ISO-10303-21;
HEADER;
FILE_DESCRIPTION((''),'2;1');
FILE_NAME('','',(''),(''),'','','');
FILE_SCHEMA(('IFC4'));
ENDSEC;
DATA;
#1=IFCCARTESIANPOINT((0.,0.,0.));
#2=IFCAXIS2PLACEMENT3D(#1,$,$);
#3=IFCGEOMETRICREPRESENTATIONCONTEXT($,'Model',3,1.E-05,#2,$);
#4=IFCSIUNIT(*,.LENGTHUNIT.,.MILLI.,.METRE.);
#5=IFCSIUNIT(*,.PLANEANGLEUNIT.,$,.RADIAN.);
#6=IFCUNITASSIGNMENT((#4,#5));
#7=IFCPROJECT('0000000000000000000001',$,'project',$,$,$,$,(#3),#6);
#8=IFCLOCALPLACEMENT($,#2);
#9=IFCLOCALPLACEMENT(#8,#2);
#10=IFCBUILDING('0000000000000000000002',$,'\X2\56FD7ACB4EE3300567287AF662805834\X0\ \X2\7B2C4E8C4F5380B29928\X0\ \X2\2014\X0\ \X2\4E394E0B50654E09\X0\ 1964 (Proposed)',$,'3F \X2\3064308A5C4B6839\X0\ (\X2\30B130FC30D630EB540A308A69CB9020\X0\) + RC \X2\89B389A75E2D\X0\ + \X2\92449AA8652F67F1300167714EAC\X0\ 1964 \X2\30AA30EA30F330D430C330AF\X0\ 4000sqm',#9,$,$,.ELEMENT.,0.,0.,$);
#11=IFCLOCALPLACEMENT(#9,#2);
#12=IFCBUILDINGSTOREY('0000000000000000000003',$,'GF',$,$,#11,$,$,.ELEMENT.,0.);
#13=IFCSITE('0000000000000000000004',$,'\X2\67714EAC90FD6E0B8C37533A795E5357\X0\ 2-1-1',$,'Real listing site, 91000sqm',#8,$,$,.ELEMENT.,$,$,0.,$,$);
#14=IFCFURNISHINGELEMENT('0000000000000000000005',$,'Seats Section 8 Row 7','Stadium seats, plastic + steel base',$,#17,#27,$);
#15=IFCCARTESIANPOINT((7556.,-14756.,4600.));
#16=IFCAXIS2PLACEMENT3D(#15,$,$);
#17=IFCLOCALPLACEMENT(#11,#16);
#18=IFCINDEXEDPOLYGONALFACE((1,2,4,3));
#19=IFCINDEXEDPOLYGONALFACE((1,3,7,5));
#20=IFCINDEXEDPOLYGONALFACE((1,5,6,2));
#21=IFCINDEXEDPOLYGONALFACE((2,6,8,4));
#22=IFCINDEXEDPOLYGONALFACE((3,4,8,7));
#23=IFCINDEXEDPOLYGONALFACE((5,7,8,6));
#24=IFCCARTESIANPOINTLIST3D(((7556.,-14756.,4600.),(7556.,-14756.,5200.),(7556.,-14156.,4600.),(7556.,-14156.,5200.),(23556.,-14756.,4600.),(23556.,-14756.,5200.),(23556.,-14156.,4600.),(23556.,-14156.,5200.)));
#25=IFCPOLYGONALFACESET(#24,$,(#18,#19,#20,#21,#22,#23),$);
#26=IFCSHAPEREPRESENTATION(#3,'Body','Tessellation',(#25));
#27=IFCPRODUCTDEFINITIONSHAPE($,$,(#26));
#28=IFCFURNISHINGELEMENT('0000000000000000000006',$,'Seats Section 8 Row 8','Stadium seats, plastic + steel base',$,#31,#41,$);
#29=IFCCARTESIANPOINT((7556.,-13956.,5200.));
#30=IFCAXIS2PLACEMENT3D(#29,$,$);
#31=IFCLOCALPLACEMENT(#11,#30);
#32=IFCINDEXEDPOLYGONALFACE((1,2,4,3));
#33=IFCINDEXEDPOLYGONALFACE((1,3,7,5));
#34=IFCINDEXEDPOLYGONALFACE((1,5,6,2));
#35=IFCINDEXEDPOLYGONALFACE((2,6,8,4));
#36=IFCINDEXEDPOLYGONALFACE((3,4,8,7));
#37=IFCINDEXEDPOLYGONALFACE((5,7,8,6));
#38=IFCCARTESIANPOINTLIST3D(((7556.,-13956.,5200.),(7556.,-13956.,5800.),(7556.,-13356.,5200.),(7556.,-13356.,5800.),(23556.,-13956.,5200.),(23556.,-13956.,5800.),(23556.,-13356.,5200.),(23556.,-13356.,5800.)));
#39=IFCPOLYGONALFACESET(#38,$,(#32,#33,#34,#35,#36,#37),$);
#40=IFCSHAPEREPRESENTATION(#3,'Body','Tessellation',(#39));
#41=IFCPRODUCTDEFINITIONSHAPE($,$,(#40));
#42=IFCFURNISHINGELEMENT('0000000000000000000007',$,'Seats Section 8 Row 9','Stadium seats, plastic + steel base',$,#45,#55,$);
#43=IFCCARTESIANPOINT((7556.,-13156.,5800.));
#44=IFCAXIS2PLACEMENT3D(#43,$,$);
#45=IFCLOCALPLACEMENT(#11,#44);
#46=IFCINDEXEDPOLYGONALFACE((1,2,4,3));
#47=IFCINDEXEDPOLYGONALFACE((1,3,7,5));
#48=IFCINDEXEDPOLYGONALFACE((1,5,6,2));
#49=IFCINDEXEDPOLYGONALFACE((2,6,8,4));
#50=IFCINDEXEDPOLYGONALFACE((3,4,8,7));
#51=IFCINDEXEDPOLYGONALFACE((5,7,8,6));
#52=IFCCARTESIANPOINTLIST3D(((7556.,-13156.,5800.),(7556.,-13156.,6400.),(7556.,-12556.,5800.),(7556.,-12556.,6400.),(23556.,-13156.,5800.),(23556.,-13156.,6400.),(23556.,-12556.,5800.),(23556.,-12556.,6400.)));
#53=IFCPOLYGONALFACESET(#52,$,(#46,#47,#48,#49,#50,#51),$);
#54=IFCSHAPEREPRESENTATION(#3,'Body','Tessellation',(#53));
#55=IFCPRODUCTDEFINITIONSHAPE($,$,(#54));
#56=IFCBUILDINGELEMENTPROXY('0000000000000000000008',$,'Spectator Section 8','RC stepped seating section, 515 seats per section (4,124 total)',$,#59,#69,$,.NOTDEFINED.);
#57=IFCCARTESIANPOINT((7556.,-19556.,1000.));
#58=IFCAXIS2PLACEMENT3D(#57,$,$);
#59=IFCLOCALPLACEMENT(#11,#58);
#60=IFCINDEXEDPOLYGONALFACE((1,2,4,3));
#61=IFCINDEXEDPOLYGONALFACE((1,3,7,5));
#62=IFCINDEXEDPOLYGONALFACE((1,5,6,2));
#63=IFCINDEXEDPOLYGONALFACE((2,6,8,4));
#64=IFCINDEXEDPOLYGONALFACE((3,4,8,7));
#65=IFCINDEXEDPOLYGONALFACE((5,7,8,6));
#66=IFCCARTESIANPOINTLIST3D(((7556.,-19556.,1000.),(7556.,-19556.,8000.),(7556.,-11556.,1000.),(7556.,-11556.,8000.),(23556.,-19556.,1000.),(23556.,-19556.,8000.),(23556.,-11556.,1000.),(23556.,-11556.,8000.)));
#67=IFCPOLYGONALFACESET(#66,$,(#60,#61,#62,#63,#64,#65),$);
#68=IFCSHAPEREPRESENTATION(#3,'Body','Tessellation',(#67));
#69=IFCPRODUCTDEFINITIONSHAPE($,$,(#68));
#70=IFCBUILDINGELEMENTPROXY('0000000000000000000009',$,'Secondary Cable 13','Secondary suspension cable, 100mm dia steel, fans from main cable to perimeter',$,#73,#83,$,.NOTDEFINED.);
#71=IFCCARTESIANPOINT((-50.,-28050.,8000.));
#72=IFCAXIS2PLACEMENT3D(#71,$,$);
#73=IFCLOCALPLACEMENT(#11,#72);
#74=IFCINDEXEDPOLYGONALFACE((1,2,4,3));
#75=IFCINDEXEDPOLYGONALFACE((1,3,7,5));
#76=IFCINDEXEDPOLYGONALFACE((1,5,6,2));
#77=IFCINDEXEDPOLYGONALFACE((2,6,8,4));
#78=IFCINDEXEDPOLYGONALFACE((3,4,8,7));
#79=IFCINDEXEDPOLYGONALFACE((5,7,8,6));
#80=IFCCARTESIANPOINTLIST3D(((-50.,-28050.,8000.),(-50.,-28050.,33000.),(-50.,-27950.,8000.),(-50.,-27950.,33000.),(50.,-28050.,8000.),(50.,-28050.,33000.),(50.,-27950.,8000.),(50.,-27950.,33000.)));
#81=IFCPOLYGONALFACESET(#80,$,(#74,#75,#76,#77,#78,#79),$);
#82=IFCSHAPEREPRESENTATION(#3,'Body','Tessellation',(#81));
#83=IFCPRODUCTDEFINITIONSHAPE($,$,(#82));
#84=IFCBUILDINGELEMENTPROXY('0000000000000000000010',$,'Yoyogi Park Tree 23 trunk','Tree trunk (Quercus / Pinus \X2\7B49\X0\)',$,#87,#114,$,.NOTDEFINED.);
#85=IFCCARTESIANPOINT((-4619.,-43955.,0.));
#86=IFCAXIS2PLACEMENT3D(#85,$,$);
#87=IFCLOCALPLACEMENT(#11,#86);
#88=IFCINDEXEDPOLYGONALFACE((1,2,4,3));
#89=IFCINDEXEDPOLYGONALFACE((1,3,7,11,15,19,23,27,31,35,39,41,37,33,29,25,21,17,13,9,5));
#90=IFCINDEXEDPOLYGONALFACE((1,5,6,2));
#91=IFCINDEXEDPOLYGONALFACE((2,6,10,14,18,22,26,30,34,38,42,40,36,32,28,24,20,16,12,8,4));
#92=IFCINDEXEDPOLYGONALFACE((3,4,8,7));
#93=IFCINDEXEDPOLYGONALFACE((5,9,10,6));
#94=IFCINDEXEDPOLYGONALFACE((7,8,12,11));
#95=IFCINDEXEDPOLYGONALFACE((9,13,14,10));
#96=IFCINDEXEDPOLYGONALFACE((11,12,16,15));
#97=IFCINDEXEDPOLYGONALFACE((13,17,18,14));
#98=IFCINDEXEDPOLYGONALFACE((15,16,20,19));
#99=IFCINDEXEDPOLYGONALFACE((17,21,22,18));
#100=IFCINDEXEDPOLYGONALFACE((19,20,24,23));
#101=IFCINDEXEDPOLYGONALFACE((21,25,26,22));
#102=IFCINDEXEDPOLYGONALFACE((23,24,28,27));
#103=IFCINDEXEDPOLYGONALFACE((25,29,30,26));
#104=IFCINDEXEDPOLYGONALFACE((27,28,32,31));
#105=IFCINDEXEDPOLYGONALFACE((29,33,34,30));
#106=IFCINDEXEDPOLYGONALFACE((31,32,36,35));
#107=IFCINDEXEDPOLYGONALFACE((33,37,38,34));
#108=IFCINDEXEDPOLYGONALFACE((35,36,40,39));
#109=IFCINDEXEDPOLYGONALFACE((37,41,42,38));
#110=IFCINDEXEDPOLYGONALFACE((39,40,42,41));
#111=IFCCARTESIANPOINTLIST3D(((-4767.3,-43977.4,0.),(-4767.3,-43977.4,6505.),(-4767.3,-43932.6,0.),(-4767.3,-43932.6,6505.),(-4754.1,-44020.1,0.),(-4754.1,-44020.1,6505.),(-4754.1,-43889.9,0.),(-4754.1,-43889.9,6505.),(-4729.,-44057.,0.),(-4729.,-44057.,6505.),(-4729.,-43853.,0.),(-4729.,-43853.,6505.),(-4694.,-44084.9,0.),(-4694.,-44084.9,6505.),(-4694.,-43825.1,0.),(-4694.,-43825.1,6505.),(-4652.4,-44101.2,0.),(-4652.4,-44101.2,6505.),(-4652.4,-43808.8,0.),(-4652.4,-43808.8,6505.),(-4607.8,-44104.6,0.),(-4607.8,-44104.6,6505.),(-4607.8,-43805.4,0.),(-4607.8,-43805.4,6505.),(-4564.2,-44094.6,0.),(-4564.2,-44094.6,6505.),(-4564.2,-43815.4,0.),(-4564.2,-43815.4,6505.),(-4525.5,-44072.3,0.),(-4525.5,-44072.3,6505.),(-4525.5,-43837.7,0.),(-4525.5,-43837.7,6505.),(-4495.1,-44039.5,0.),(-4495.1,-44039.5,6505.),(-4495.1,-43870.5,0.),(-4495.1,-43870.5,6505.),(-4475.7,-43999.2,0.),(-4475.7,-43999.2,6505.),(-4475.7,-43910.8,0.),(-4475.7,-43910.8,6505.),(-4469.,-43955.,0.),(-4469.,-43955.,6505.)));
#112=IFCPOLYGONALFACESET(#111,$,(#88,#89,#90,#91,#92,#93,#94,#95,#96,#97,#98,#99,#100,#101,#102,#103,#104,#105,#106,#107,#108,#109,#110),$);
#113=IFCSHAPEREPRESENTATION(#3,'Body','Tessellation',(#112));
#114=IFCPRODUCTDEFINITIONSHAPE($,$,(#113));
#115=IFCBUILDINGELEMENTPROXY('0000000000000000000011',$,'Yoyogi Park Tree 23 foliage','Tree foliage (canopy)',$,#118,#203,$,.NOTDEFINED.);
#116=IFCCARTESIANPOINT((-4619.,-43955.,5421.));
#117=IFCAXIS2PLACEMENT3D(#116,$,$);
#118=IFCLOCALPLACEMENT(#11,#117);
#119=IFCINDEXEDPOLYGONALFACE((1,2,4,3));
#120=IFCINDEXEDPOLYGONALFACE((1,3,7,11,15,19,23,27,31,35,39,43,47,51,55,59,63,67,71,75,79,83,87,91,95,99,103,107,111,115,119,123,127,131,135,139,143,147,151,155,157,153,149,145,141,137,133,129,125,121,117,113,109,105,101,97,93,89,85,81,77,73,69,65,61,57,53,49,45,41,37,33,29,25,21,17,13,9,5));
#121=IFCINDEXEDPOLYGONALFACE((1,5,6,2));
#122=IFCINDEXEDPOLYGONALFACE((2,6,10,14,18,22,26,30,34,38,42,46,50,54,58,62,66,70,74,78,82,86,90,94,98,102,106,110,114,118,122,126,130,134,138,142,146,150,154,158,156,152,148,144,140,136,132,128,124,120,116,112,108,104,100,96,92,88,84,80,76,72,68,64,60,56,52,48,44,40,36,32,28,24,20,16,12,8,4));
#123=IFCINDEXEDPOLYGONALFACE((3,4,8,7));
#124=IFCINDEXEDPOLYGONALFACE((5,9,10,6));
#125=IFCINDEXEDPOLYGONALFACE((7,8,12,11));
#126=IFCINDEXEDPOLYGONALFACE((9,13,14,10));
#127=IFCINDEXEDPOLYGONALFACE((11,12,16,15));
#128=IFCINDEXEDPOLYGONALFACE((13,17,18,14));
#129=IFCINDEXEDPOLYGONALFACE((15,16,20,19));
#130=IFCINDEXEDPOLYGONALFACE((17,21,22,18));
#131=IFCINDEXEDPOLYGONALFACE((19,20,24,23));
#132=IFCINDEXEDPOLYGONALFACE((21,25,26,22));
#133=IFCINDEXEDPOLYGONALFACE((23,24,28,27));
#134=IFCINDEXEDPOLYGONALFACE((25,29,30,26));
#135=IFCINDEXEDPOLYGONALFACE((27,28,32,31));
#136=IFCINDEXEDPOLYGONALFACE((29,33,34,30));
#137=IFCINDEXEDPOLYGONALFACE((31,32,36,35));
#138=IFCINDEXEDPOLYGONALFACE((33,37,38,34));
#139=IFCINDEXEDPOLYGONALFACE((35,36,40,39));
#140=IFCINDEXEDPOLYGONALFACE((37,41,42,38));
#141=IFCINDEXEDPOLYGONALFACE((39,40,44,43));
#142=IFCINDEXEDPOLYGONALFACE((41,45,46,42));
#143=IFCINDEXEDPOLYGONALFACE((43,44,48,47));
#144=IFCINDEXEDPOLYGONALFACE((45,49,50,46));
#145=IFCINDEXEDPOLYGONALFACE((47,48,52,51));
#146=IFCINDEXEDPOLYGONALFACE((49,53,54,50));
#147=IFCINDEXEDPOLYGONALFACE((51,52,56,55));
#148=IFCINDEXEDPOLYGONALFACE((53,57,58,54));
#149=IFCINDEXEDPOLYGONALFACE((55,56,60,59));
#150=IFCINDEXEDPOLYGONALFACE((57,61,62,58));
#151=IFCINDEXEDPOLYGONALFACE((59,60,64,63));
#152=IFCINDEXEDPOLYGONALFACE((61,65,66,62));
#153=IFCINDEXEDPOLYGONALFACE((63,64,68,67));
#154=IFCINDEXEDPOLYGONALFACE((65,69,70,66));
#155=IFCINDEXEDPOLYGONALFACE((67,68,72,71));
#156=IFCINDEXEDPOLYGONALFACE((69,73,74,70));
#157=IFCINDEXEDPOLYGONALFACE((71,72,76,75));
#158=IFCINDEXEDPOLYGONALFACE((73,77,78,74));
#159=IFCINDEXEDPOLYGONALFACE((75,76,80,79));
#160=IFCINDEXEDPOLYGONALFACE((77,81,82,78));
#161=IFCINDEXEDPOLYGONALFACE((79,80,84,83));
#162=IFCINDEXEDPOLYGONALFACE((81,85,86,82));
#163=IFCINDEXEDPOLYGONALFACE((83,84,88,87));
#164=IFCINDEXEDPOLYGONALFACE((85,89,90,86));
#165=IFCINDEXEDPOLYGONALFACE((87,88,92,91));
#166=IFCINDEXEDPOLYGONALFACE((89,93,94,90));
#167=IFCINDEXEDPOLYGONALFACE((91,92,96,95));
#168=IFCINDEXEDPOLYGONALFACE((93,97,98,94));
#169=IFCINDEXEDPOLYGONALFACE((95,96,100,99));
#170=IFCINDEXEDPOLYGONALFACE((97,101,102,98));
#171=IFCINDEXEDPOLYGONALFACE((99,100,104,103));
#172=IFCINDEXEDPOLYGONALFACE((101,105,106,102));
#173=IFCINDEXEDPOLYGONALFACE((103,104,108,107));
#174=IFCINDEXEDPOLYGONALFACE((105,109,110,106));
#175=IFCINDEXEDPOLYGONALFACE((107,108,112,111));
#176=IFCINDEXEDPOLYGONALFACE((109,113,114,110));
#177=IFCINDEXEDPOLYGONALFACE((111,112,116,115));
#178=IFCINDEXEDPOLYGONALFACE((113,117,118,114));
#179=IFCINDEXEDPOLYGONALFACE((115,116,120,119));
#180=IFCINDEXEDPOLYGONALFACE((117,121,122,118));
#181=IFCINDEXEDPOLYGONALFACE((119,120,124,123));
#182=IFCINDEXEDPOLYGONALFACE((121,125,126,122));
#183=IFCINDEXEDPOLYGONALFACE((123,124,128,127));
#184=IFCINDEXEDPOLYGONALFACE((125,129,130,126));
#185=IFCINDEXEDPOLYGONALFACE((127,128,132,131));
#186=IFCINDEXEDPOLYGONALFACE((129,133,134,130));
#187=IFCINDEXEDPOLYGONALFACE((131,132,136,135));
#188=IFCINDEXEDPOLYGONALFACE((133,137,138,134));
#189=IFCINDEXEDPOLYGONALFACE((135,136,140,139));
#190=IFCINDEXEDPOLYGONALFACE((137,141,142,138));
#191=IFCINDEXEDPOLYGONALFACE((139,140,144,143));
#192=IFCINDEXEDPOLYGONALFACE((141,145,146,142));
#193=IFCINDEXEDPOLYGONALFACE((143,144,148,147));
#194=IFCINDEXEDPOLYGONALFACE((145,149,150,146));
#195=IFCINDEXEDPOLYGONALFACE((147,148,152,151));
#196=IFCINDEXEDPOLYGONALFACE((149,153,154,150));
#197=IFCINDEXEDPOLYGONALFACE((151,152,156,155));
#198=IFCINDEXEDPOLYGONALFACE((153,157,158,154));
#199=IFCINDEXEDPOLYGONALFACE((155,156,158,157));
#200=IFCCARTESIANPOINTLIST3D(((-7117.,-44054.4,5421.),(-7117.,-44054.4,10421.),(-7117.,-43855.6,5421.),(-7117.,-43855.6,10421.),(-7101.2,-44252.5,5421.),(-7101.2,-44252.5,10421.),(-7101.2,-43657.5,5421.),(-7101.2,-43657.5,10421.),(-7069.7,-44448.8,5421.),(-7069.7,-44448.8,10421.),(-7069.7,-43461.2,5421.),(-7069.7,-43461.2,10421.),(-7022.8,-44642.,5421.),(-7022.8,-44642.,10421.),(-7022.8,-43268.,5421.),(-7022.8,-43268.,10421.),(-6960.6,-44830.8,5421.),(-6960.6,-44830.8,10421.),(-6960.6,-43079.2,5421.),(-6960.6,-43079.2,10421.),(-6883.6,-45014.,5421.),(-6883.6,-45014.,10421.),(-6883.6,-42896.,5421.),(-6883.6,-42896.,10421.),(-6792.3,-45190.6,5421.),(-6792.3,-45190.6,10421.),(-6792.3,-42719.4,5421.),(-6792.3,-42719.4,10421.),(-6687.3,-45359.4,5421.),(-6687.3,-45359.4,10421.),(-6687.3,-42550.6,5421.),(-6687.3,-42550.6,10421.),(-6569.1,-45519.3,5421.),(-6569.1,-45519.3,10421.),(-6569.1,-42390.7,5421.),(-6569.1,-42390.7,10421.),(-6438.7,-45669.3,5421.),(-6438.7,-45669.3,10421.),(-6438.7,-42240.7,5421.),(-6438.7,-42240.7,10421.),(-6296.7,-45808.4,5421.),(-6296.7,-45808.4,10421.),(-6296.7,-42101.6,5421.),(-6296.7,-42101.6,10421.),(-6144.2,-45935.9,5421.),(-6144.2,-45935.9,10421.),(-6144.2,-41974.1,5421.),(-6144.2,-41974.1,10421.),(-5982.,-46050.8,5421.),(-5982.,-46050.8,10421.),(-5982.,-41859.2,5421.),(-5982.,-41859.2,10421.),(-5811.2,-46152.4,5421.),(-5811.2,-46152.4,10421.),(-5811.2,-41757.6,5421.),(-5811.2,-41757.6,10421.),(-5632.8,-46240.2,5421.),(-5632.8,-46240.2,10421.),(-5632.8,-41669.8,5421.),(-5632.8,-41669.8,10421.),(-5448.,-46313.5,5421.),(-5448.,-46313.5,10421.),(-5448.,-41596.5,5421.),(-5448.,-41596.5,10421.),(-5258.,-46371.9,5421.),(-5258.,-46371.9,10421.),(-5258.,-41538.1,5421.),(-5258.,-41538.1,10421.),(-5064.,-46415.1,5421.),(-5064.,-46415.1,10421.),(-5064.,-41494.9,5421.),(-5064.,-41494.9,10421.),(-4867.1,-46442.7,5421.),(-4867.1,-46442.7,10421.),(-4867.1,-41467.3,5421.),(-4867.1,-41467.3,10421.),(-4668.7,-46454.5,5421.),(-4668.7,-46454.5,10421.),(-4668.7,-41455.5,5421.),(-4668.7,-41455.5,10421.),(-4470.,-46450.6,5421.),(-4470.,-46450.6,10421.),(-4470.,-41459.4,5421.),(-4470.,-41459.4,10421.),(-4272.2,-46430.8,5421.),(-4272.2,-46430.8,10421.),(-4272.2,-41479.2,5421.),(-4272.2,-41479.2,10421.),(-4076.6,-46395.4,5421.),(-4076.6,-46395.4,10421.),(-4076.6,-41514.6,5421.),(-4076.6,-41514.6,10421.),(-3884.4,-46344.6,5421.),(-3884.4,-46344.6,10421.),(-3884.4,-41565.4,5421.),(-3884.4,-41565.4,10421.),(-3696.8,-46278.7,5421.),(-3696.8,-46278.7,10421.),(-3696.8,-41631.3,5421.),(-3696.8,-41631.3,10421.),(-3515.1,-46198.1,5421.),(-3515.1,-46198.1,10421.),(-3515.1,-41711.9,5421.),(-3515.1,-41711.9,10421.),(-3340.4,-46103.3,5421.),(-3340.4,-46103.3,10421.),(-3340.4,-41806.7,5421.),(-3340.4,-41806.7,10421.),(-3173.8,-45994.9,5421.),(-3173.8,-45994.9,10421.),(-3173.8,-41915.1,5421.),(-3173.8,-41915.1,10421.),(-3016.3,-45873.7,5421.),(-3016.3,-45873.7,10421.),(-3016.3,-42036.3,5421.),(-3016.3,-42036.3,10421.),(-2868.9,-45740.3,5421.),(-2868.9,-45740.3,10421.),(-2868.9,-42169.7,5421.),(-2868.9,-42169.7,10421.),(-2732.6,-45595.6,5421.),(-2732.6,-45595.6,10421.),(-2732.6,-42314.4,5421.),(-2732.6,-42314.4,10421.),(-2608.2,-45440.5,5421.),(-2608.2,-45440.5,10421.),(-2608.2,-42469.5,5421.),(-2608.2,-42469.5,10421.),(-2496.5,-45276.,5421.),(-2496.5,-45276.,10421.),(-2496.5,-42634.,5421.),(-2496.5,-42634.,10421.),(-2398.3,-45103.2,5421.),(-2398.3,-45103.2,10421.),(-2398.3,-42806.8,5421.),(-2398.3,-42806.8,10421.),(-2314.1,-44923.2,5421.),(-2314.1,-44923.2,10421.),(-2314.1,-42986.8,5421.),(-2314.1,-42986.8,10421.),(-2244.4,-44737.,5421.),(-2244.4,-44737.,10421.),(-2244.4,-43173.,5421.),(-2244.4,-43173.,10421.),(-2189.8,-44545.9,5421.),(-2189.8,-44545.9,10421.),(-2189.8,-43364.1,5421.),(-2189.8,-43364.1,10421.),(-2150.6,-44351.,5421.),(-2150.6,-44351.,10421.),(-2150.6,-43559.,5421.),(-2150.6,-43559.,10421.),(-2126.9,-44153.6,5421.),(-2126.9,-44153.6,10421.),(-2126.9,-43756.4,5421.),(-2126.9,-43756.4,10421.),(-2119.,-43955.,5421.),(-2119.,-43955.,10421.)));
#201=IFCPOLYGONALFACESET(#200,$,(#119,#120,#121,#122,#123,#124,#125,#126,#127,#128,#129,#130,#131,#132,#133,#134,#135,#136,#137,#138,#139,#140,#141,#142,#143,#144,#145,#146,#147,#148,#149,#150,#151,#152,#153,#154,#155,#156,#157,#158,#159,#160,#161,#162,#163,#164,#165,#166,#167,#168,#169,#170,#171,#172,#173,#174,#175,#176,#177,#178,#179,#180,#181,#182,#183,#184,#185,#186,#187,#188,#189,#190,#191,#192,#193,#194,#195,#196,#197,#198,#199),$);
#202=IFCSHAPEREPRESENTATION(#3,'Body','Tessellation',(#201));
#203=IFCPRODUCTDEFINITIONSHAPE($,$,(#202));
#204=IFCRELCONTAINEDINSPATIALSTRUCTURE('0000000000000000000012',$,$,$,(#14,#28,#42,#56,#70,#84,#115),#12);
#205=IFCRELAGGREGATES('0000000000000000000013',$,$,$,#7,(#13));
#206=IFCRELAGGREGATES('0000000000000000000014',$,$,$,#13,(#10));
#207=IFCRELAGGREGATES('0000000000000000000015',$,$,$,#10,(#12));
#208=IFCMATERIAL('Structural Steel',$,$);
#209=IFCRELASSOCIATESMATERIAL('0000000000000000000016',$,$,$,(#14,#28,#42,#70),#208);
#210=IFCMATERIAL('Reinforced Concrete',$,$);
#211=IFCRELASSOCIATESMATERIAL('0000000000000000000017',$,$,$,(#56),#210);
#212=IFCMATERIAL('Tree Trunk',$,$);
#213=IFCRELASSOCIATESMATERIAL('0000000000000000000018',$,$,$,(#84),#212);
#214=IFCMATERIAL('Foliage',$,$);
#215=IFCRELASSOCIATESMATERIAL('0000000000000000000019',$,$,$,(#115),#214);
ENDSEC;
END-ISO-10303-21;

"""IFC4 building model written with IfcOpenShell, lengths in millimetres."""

from ifc_helpers import new_model, si_unit, frame, frame_2d, origin, origin_2d, place, context, project, spatial, rectangle, circle, extrude, material, element, save


model = new_model("IFC4")

# Units and contexts
model_context = context("Model", 3, precision=1e-05, world=origin())
ifc_project = project(units=[si_unit("LENGTHUNIT", "METRE", prefix="MILLI"), si_unit("PLANEANGLEUNIT", "RADIAN")], contexts=[model_context])

# Site, building, storey
site_placement = place(None, origin())
site = spatial("IfcSite", under=ifc_project, at=site_placement, Name="東京都渋谷区神南 2-1-1", ObjectType="Real listing site, 91000sqm", CompositionType="ELEMENT", RefElevation=0.0)
building_placement = place(site_placement, origin())
building = spatial("IfcBuilding", under=site, at=building_placement, Name="国立代々木競技場 第二体育館 — 丹下健三 1964 (Proposed)", ObjectType="3F つり屋根 (ケーブル吊り構造) + RC 観覧席 + 鉄骨支柱、東京 1964 オリンピック 4000sqm", CompositionType="ELEMENT", ElevationOfRefHeight=0.0, ElevationOfTerrain=0.0)
storey_placement = place(building_placement, origin())
storey = spatial("IfcBuildingStorey", under=building, at=storey_placement, Name="GF", CompositionType="ELEMENT", Elevation=0.0)

# Shared definitions
ifc_material_1 = material(Name="Structural Steel")

# Furnishing elements
furnishing_1_placement = place(storey_placement, frame((7556.0, -14756.0, 4600.0)))
element("IfcFurnishingElement", 1, at=furnishing_1_placement, inside=storey, material=ifc_material_1, Name="Seats Section 8 Row 7", Description="Stadium seats, plastic + steel base", context=model_context, shape_type="SweptSolid", body=[
    extrude(rectangle(XDim=16000.0, YDim=600.0, at=frame_2d((8000.0, 300.0))), frame((7556.0, -14756.0, 4600.0)), (0.0, 0.0, 1.0), 600.0),
])
furnishing_2_placement = place(storey_placement, frame((7556.0, -13956.0, 5200.0)))
element("IfcFurnishingElement", 2, at=furnishing_2_placement, inside=storey, material=ifc_material_1, Name="Seats Section 8 Row 8", Description="Stadium seats, plastic + steel base", context=model_context, shape_type="SweptSolid", body=[
    extrude(rectangle(XDim=16000.0, YDim=600.0, at=frame_2d((8000.0, 300.0))), frame((7556.0, -13956.0, 5200.0)), (0.0, 0.0, 1.0), 600.0),
])
furnishing_3_placement = place(storey_placement, frame((7556.0, -13156.0, 5800.0)))
element("IfcFurnishingElement", 3, at=furnishing_3_placement, inside=storey, material=ifc_material_1, Name="Seats Section 8 Row 9", Description="Stadium seats, plastic + steel base", context=model_context, shape_type="SweptSolid", body=[
    extrude(rectangle(XDim=16000.0, YDim=600.0, at=frame_2d((8000.0, 300.0))), frame((7556.0, -13156.0, 5800.0)), (0.0, 0.0, 1.0), 600.0),
])

# Building element proxies
ifc_material_2 = material(Name="Reinforced Concrete")
proxy_1_placement = place(storey_placement, frame((7556.0, -19556.0, 1000.0)))
element("IfcBuildingElementProxy", 4, at=proxy_1_placement, inside=storey, material=ifc_material_2, Name="Spectator Section 8", Description="RC stepped seating section, 515 seats per section (4,124 total)", PredefinedType="NOTDEFINED", context=model_context, shape_type="SweptSolid", body=[
    extrude(rectangle(XDim=16000.0, YDim=8000.0, at=frame_2d((8000.0, 4000.0))), frame((7556.0, -19556.0, 1000.0)), (0.0, 0.0, 1.0), 7000.0),
])
proxy_2_placement = place(storey_placement, frame((-50.0, -28050.0, 8000.0)))
element("IfcBuildingElementProxy", 5, at=proxy_2_placement, inside=storey, material=ifc_material_1, Name="Secondary Cable 13", Description="Secondary suspension cable, 100mm dia steel, fans from main cable to perimeter", PredefinedType="NOTDEFINED", context=model_context, shape_type="SweptSolid", body=[
    extrude(rectangle(XDim=100.0, YDim=100.0, at=frame_2d((50.0, 50.0))), frame((-50.0, -28050.0, 8000.0)), (0.0, 0.0, 1.0), 25000.0),
])
ifc_material_3 = material(Name="Tree Trunk")
proxy_3_placement = place(storey_placement, frame((-4619.0, -43955.0, 0.0)))
element("IfcBuildingElementProxy", 6, at=proxy_3_placement, inside=storey, material=ifc_material_3, Name="Yoyogi Park Tree 23 trunk", Description="Tree trunk (Quercus / Pinus 等)", PredefinedType="NOTDEFINED", context=model_context, shape_type="SweptSolid", body=[
    extrude(circle(Radius=150.0, at=origin_2d()), frame((-4619.0, -43955.0, 0.0)), (0.0, 0.0, 1.0), 6505.0),
])
ifc_material_4 = material(Name="Foliage")
proxy_4_placement = place(storey_placement, frame((-4619.0, -43955.0, 5421.0)))
element("IfcBuildingElementProxy", 7, at=proxy_4_placement, inside=storey, material=ifc_material_4, Name="Yoyogi Park Tree 23 foliage", Description="Tree foliage (canopy)", PredefinedType="NOTDEFINED", context=model_context, shape_type="SweptSolid", body=[
    extrude(circle(Radius=2500.0, at=origin_2d()), frame((-4619.0, -43955.0, 5421.0)), (0.0, 0.0, 1.0), 5000.0),
])

save(model, "model.ifc")
